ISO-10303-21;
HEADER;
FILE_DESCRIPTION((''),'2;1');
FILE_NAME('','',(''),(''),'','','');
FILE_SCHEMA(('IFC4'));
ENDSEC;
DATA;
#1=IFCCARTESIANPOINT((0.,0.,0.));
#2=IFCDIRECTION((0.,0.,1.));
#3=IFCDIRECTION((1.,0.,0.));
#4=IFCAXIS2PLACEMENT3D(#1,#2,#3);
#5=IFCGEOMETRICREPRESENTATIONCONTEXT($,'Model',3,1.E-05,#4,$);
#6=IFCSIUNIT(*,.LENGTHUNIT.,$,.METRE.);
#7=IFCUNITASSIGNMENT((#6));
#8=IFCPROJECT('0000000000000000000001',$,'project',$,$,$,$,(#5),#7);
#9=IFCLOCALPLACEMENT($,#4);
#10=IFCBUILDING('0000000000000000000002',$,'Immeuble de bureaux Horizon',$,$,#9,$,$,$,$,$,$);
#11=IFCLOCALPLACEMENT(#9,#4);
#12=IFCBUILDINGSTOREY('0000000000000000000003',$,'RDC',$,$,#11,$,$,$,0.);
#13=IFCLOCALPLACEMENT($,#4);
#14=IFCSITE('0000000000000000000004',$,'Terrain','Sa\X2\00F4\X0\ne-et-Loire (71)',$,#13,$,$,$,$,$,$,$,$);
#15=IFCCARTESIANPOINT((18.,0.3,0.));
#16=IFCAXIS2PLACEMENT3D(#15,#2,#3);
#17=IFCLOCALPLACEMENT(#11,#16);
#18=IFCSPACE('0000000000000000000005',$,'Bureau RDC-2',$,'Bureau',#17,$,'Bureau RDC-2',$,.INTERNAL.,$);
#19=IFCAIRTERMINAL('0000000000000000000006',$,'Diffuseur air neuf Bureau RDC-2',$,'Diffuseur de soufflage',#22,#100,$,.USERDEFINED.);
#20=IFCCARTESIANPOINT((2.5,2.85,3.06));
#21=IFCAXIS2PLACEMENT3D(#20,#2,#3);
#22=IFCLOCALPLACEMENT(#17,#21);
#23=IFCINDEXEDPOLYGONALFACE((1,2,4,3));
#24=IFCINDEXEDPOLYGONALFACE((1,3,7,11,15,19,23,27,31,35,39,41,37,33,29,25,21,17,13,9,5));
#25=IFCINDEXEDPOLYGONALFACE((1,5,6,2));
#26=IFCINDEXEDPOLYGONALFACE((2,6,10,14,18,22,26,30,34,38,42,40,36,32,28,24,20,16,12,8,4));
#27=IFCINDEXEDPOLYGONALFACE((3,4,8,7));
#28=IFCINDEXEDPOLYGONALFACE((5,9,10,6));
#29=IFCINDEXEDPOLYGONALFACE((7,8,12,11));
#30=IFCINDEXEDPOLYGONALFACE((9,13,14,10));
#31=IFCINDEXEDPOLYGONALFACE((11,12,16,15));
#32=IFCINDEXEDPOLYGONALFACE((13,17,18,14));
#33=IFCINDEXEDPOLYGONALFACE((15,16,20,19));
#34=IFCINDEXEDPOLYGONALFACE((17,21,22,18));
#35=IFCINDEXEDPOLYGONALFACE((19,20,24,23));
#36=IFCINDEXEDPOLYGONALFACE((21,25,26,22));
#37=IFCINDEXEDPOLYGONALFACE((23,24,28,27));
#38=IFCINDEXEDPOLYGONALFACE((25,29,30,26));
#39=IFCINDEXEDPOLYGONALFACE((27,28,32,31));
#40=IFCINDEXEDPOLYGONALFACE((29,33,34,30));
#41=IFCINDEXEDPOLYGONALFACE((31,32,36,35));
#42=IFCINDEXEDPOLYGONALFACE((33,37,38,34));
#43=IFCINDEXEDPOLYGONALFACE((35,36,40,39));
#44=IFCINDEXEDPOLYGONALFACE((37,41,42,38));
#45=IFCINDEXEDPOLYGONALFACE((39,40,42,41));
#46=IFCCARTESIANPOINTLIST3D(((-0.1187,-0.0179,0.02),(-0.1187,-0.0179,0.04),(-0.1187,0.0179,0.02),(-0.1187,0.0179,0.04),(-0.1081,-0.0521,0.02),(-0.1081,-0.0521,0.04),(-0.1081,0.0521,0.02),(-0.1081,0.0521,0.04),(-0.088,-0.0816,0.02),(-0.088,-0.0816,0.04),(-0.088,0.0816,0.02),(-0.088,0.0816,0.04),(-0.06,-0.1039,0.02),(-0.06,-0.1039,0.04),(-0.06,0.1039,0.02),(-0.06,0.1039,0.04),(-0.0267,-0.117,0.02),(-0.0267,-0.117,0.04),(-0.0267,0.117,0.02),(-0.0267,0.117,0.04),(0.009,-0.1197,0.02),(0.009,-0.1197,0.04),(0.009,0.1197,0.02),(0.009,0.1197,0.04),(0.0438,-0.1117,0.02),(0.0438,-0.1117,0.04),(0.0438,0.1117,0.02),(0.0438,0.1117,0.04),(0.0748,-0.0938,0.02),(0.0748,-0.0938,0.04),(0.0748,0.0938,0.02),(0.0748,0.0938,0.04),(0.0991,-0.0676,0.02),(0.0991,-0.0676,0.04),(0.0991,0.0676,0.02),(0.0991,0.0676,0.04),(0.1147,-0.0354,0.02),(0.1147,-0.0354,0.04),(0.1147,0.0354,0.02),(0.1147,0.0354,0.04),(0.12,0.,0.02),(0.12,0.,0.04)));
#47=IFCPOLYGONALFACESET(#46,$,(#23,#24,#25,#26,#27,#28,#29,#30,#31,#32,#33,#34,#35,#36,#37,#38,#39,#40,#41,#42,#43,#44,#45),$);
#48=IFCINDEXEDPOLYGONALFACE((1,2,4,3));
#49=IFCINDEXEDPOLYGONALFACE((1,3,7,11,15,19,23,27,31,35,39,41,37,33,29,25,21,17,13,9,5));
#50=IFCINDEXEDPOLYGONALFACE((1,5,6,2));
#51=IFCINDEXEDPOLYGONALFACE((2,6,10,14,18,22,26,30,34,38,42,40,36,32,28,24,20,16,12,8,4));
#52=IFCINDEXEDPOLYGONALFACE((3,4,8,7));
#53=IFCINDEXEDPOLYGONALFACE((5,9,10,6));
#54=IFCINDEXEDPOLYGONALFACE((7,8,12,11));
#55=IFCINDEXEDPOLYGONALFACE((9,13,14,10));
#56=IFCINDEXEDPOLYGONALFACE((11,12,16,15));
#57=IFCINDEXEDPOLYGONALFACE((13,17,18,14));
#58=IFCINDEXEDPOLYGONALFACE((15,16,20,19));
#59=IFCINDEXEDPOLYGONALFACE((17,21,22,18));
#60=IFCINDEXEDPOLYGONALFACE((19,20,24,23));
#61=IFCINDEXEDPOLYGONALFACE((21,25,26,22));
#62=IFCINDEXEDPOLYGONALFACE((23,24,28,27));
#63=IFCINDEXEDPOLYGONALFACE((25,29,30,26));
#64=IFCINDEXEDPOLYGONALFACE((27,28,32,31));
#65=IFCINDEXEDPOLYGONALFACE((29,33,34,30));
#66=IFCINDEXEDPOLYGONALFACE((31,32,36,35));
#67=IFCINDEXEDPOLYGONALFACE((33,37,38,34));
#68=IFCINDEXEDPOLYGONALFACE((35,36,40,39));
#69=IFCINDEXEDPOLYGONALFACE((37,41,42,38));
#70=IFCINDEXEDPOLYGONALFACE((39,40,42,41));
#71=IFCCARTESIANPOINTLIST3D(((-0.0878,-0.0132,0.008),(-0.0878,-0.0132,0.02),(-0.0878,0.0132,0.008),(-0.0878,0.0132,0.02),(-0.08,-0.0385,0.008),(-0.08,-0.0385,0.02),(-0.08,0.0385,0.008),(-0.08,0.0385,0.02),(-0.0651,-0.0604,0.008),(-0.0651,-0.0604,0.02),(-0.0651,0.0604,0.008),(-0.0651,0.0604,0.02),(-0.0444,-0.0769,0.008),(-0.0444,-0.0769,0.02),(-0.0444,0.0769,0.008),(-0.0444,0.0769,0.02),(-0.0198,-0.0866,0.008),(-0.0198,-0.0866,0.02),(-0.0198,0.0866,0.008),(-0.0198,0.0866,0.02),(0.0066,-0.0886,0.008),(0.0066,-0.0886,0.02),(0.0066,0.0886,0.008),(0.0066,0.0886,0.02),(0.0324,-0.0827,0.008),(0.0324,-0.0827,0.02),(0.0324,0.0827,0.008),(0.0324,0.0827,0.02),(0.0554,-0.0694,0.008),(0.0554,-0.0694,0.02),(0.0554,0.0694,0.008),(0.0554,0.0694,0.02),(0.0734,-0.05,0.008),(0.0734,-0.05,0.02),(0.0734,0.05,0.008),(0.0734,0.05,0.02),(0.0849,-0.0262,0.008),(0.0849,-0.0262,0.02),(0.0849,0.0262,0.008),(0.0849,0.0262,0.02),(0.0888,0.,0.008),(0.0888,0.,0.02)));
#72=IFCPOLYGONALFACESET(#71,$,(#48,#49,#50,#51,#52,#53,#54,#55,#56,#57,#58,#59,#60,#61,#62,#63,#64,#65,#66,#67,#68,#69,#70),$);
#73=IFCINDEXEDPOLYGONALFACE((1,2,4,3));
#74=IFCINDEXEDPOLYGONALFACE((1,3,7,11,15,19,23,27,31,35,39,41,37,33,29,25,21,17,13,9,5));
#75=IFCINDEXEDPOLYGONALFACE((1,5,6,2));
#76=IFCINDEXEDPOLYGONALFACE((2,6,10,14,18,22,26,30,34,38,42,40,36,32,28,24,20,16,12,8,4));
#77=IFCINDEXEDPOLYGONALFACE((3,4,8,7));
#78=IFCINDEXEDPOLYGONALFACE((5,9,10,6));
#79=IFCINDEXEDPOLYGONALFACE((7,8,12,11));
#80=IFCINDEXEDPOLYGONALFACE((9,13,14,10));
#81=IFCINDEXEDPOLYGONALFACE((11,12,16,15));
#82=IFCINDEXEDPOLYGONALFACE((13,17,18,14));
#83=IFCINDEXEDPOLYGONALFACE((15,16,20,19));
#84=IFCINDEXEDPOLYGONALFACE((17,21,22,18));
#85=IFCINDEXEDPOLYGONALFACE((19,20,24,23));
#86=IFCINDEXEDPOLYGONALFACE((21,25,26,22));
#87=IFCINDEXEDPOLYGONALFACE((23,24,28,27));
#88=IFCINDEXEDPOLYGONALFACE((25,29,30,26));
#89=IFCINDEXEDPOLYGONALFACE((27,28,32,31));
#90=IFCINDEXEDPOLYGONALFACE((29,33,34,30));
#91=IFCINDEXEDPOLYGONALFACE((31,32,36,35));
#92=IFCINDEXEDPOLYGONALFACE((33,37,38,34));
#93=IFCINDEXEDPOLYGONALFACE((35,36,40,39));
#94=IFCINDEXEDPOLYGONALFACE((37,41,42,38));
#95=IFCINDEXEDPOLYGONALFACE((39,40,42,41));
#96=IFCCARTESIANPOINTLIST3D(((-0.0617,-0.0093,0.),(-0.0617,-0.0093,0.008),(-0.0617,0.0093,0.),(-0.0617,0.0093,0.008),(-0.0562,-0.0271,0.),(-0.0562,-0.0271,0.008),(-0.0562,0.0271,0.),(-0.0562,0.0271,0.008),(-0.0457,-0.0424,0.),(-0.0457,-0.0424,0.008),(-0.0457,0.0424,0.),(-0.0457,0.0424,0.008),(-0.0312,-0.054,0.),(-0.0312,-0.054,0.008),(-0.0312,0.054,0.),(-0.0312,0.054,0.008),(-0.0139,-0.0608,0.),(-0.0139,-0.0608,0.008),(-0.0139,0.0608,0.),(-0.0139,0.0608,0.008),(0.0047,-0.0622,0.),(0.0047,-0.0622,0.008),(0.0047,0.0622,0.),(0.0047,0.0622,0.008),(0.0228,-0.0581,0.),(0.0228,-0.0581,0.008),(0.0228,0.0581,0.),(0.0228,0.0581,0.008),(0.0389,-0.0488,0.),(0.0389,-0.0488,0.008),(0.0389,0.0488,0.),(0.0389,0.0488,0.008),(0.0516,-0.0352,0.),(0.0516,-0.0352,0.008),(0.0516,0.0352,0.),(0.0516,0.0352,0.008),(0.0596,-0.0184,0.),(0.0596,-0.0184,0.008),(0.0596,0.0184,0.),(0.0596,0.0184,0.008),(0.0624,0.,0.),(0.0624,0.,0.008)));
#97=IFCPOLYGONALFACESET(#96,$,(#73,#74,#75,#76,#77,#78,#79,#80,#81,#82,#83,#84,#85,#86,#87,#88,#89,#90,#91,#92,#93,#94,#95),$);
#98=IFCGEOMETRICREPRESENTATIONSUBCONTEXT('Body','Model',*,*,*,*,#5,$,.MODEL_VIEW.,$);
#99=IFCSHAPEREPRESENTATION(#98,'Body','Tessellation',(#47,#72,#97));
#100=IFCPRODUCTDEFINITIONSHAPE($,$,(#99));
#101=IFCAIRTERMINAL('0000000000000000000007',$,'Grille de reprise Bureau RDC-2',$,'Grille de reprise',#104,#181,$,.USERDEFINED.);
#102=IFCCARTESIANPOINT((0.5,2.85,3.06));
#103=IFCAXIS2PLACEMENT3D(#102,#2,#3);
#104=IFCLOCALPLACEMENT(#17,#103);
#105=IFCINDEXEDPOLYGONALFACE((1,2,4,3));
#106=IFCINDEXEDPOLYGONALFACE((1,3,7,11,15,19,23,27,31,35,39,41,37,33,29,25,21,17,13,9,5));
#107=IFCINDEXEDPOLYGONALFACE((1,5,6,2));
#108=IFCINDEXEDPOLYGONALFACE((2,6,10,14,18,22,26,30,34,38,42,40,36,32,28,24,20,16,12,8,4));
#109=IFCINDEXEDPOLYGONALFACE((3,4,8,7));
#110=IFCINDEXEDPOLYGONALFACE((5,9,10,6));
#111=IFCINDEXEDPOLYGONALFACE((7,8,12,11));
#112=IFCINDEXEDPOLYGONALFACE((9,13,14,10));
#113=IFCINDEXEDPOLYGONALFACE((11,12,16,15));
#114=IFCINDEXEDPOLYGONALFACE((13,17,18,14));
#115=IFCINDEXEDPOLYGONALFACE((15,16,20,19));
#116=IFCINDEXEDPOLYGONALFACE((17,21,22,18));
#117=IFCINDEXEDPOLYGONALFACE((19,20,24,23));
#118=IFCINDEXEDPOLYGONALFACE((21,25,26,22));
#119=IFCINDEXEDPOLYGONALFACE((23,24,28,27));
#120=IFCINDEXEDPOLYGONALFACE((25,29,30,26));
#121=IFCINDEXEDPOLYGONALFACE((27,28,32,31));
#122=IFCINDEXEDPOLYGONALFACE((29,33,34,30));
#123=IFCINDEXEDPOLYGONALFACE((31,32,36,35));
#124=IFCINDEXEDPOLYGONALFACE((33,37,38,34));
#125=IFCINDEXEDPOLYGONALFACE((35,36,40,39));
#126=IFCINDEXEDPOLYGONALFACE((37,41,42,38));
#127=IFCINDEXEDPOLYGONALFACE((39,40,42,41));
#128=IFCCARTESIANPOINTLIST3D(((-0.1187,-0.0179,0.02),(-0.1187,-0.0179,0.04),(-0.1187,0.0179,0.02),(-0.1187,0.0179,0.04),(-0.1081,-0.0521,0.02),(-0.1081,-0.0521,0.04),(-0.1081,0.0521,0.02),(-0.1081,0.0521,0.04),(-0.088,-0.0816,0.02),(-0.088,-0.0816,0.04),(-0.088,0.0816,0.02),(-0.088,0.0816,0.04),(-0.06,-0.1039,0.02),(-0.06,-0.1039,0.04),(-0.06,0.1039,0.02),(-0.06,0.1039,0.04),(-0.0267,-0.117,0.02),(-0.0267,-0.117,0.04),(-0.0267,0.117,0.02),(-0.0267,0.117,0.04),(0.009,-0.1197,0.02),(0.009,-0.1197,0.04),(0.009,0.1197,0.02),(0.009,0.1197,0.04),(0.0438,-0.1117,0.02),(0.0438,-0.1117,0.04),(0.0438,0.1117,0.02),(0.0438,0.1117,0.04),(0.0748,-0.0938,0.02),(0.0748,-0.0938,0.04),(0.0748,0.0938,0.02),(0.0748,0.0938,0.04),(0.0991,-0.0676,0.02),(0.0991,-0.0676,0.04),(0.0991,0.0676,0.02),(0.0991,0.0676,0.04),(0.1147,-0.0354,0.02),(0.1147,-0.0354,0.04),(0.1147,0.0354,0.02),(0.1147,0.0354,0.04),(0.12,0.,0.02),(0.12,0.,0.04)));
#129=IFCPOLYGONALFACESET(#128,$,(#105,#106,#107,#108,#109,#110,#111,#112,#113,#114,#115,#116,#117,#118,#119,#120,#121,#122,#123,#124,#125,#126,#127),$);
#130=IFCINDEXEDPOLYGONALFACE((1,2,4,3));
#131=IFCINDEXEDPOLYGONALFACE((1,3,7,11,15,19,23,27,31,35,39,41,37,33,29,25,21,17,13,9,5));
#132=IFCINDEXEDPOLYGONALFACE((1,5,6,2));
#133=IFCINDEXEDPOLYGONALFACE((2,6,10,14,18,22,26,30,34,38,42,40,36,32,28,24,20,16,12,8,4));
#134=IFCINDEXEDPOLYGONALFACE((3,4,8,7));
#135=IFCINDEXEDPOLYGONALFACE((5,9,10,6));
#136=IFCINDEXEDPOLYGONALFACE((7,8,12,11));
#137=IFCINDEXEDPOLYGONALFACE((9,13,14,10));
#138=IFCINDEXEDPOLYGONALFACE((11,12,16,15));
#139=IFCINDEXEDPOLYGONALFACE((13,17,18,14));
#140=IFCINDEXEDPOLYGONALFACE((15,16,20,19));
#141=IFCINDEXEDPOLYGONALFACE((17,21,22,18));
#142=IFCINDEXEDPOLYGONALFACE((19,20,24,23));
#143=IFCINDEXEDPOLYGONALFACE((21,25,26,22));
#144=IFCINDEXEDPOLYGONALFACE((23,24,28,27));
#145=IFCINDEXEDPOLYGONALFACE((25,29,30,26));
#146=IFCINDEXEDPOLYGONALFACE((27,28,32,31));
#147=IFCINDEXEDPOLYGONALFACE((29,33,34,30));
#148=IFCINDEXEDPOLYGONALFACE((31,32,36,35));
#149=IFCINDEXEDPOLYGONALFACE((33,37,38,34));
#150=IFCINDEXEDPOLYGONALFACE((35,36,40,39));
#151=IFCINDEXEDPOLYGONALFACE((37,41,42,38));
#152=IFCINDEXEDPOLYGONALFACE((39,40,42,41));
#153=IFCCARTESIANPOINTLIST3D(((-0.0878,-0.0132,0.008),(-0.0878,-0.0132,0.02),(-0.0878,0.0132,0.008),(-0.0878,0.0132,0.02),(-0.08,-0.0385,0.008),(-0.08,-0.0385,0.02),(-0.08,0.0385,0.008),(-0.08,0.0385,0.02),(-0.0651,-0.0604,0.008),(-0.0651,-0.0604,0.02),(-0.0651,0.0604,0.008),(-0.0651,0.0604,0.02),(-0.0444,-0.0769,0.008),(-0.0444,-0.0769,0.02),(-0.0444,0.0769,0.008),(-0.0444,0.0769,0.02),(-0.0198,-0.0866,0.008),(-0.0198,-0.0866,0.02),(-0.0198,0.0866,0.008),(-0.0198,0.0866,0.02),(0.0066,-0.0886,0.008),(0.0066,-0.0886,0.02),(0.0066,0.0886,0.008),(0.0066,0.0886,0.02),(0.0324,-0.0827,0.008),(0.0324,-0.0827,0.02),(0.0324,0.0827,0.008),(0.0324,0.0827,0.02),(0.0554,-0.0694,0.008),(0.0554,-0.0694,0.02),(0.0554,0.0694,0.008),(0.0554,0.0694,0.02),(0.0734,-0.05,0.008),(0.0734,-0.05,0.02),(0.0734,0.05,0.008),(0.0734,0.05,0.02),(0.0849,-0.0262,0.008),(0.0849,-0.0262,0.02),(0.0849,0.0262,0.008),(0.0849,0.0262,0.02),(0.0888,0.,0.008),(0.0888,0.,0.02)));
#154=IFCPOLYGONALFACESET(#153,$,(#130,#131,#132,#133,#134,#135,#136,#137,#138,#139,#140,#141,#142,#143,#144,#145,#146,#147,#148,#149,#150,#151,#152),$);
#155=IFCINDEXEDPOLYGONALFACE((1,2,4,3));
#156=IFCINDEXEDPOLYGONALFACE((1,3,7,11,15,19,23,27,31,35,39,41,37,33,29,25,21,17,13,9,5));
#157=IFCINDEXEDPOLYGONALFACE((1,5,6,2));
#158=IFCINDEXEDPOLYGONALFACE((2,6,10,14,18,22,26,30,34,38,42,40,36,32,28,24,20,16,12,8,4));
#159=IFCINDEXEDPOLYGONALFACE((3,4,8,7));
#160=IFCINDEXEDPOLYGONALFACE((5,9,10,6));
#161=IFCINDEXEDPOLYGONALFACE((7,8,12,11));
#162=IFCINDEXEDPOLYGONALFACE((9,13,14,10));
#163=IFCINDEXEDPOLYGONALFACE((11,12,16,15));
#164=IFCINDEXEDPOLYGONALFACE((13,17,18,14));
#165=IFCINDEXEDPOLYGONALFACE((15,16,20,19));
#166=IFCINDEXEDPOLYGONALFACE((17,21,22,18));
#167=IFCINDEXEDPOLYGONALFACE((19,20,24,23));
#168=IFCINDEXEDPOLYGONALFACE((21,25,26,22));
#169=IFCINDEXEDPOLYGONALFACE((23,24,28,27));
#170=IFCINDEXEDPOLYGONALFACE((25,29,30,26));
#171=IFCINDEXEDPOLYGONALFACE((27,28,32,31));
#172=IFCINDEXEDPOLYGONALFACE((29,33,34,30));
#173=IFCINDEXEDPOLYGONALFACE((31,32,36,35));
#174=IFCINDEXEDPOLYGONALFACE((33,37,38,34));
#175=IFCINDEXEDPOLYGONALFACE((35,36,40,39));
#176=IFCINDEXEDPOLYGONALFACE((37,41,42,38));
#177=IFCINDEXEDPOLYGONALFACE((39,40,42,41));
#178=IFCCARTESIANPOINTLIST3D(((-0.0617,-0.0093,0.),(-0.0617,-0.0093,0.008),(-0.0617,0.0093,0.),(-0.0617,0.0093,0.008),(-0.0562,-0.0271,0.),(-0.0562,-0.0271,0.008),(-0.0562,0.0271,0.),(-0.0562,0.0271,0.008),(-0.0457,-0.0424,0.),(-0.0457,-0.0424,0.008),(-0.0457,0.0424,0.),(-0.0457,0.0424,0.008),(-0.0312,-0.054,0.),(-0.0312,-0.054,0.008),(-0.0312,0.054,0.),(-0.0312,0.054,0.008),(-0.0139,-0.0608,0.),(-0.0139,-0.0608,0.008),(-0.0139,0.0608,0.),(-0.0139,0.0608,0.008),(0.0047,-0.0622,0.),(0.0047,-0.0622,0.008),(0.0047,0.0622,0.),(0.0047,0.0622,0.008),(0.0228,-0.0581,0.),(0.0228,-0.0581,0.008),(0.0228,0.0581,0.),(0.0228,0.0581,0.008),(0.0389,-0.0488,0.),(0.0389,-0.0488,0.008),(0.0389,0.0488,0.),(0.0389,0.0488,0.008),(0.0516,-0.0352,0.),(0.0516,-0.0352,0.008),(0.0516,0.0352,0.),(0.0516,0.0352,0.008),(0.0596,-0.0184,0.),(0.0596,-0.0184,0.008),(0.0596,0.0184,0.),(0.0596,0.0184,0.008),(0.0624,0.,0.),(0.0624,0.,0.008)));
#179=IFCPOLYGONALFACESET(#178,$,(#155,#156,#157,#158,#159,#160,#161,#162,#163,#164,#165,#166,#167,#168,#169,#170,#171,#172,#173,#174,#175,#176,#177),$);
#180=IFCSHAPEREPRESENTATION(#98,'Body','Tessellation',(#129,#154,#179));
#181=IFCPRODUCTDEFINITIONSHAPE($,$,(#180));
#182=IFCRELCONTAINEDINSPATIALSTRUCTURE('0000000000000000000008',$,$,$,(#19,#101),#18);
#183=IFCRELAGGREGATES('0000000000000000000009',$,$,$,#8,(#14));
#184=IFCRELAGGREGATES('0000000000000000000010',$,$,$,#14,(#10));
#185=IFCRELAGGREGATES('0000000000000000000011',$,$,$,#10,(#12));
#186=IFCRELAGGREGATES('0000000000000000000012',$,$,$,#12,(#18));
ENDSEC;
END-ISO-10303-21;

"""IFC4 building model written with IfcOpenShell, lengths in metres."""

from ifc_helpers import new_model, si_unit, frame, origin_with_axes, place, context, subcontext, project, spatial, circle, extrude, element, save


model = new_model("IFC4")

# Units and contexts
model_context = context("Model", 3, precision=1e-05, world=origin_with_axes())
body_context = subcontext(model_context, "Body", "Model", "MODEL_VIEW")
ifc_project = project(units=[si_unit("LENGTHUNIT", "METRE")], contexts=[model_context])

# Site, building, storey
site_placement = place(None, origin_with_axes())
site = spatial("IfcSite", under=ifc_project, at=site_placement, Name="Terrain", Description="Saône-et-Loire (71)")
building_placement = place(None, origin_with_axes())
building = spatial("IfcBuilding", under=site, at=building_placement, Name="Immeuble de bureaux Horizon")
storey_placement = place(building_placement, origin_with_axes())
storey = spatial("IfcBuildingStorey", under=building, at=storey_placement, Name="RDC", Elevation=0.0)

# Shared definitions
space_1_placement = place(storey_placement, frame((18.0, 0.3, 0.0), z_axis=(0.0, 0.0, 1.0), x_axis=(1.0, 0.0, 0.0)))
space_1 = spatial("IfcSpace", under=storey, at=space_1_placement, Name="Bureau RDC-2", ObjectType="Bureau", LongName="Bureau RDC-2", PredefinedType="INTERNAL")

# Air terminal
air_terminal_1_placement = place(space_1_placement, frame((2.5, 2.85, 3.06), z_axis=(0.0, 0.0, 1.0), x_axis=(1.0, 0.0, 0.0)))
element("IfcAirTerminal", 1, at=air_terminal_1_placement, inside=space_1, Name="Diffuseur air neuf Bureau RDC-2", ObjectType="Diffuseur de soufflage", PredefinedType="USERDEFINED", context=body_context, shape_type="SweptSolid", body=[
    extrude(circle(Radius=0.12), frame((0.0, 0.0, 0.02), z_axis=(0.0, 0.0, 1.0), x_axis=(1.0, 0.0, 0.0)), (0.0, 0.0, 1.0), 0.02),
    extrude(circle(Radius=0.0888), frame((0.0, 0.0, 0.008), z_axis=(0.0, 0.0, 1.0), x_axis=(1.0, 0.0, 0.0)), (0.0, 0.0, 1.0), 0.012),
    extrude(circle(Radius=0.0624), origin_with_axes(), (0.0, 0.0, 1.0), 0.008),
])

# Air terminal
air_terminal_2_placement = place(space_1_placement, frame((0.5, 2.85, 3.06), z_axis=(0.0, 0.0, 1.0), x_axis=(1.0, 0.0, 0.0)))
element("IfcAirTerminal", 2, at=air_terminal_2_placement, inside=space_1, Name="Grille de reprise Bureau RDC-2", ObjectType="Grille de reprise", PredefinedType="USERDEFINED", context=body_context, shape_type="SweptSolid", body=[
    extrude(circle(Radius=0.12), frame((0.0, 0.0, 0.02), z_axis=(0.0, 0.0, 1.0), x_axis=(1.0, 0.0, 0.0)), (0.0, 0.0, 1.0), 0.02),
    extrude(circle(Radius=0.0888), frame((0.0, 0.0, 0.008), z_axis=(0.0, 0.0, 1.0), x_axis=(1.0, 0.0, 0.0)), (0.0, 0.0, 1.0), 0.012),
    extrude(circle(Radius=0.0624), origin_with_axes(), (0.0, 0.0, 1.0), 0.008),
])

save(model, "model.ifc")
